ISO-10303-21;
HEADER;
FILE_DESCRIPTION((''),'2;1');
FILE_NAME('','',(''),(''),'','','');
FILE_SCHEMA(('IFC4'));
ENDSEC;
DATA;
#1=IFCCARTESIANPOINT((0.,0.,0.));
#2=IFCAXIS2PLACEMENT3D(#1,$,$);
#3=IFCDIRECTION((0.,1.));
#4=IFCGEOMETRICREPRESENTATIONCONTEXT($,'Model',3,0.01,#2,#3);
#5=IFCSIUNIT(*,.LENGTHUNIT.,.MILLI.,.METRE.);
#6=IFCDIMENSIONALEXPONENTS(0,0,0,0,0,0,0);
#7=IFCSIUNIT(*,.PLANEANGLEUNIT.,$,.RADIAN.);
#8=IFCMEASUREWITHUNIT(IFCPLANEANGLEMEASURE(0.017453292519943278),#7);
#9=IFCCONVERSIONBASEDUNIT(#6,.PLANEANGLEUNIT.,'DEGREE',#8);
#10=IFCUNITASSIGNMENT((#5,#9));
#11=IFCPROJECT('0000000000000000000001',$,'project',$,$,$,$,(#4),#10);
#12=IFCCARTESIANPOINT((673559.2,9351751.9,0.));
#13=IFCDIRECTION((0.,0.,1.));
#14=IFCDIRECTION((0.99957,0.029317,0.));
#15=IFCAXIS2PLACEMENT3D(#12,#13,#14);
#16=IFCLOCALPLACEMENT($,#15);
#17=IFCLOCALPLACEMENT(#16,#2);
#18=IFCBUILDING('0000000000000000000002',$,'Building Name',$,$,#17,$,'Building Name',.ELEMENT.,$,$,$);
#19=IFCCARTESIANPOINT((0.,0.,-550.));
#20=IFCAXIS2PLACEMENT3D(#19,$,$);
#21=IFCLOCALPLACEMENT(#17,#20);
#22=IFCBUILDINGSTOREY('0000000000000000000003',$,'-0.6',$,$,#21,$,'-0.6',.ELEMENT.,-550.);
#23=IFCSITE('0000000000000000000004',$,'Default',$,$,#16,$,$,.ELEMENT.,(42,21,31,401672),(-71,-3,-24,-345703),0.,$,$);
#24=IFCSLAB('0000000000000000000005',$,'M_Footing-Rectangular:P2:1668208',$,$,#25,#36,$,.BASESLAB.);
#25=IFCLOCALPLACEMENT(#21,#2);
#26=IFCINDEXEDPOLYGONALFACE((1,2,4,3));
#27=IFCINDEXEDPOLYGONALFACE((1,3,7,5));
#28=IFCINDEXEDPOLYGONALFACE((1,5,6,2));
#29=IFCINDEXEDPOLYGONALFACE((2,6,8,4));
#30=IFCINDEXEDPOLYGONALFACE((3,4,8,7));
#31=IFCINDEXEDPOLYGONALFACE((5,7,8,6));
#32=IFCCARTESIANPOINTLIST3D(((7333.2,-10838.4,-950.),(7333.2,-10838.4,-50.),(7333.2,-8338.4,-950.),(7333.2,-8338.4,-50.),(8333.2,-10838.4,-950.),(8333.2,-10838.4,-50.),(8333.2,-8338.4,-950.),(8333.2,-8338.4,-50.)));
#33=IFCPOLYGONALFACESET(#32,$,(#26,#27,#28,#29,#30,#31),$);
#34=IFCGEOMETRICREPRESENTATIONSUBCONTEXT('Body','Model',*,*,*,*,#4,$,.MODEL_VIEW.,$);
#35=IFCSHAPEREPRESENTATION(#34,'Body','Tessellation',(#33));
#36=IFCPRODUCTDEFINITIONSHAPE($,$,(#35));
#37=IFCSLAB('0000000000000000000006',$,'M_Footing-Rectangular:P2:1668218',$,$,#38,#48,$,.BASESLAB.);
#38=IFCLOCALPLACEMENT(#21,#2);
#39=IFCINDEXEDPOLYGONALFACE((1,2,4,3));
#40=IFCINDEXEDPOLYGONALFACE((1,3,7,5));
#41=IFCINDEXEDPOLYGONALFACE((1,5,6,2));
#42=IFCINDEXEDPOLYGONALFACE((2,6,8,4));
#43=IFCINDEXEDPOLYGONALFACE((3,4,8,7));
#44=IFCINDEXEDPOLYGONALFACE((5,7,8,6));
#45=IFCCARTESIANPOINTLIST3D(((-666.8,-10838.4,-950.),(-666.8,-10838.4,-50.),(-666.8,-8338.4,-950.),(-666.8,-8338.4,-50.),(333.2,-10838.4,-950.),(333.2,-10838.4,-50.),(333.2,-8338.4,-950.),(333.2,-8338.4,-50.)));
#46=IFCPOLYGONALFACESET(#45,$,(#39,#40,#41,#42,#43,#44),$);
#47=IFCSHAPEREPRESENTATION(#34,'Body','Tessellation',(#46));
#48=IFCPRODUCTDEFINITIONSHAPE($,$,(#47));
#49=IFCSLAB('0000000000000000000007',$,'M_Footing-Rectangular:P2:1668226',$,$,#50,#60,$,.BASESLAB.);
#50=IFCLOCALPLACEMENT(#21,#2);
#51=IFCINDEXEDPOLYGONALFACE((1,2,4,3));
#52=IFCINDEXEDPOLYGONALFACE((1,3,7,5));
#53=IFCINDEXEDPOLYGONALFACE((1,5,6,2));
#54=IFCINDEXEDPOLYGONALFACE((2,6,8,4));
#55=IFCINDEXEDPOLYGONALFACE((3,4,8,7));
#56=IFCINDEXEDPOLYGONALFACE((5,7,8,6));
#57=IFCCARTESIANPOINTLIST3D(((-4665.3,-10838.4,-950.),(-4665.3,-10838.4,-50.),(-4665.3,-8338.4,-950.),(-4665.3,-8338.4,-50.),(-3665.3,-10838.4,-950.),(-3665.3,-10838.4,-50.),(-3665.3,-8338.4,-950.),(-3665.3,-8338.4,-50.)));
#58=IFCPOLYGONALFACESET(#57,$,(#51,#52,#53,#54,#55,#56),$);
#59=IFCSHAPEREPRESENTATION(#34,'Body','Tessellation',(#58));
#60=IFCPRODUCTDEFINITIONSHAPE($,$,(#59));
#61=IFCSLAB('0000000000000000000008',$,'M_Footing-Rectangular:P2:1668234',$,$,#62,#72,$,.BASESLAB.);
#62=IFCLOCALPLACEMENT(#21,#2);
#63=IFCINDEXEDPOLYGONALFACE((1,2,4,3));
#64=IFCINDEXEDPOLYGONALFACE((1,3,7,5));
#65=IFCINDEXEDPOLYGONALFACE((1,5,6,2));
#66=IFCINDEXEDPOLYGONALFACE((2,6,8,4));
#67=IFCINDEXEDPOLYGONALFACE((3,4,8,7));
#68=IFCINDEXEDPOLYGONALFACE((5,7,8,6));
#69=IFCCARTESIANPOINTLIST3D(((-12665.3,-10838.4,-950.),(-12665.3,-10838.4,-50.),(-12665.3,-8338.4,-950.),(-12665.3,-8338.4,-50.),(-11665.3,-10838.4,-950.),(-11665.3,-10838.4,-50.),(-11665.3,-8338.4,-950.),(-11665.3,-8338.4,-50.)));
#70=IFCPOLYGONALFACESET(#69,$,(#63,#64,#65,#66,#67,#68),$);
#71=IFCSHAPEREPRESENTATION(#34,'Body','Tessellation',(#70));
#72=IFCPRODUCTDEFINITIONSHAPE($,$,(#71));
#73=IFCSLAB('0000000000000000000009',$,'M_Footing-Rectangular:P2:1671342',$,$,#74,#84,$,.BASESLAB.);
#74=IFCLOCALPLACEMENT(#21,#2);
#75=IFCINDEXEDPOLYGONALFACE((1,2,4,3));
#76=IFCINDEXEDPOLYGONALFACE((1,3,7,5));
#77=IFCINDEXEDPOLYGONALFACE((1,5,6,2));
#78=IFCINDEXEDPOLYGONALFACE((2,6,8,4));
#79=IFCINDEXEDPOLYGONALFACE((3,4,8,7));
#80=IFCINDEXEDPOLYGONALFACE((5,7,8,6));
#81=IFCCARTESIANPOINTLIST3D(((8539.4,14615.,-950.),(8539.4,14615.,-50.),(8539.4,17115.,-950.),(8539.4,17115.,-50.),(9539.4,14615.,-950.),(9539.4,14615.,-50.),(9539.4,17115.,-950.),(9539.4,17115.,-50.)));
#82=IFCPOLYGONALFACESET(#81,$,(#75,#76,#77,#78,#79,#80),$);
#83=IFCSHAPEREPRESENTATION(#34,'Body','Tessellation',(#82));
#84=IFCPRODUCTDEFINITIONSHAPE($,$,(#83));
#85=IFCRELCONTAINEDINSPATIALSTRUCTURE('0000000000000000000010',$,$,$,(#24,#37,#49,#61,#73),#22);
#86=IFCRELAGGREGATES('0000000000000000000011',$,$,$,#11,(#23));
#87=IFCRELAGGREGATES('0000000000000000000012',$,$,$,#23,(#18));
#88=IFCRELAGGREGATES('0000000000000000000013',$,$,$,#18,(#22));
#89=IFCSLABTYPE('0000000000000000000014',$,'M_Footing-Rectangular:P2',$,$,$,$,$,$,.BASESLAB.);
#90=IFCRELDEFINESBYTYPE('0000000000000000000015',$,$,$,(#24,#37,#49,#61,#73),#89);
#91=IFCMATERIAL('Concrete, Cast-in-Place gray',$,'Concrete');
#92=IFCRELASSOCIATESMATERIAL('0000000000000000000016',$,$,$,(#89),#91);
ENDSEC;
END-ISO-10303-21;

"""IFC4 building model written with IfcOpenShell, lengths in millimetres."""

from ifc_helpers import new_model, entity, si_unit, converted_unit, direction, frame, origin, place, context, subcontext, project, spatial, indexed_curve, outline, extrude, material, type_object, element, save


model = new_model("IFC4")

# Units and contexts
model_context = context("Model", 3, precision=0.01, world=origin(), true_north=direction((0.0, 1.0)))
body_context = subcontext(model_context, "Body", "Model", "MODEL_VIEW")
ifc_project = project(units=[si_unit("LENGTHUNIT", "METRE", prefix="MILLI"), converted_unit("PLANEANGLEUNIT", "DEGREE", entity("IfcPlaneAngleMeasure", 0.017453292519943278), si_unit("PLANEANGLEUNIT", "RADIAN"), dimensions=[0, 0, 0, 0, 0, 0, 0])], contexts=[model_context])

# Site, building, storey
site_placement = place(None, frame((673559.2, 9351751.9, 0.0), z_axis=(0.0, 0.0, 1.0), x_axis=(0.99957, 0.029317, 0.0)))
site = spatial("IfcSite", under=ifc_project, at=site_placement, Name="Default", CompositionType="ELEMENT", RefLatitude=(42, 21, 31, 401672), RefLongitude=(-71, -3, -24, -345703), RefElevation=0.0)
building_placement = place(site_placement, origin())
building = spatial("IfcBuilding", under=site, at=building_placement, Name="Building Name", LongName="Building Name", CompositionType="ELEMENT")
storey_placement = place(building_placement, frame((0.0, 0.0, -550.0)))
storey = spatial("IfcBuildingStorey", under=building, at=storey_placement, Name="-0.6", LongName="-0.6", CompositionType="ELEMENT", Elevation=-550.0)

# Shared definitions
ifc_material = material(Name="Concrete, Cast-in-Place gray", Category="Concrete")

# Slabs
slab_type_1 = type_object("IfcSlabType", Name="M_Footing-Rectangular:P2", PredefinedType="BASESLAB", material=ifc_material)
slab_1_placement = place(storey_placement, origin())
element("IfcSlab", 1, at=slab_1_placement, inside=storey, type_object=slab_type_1, Name="M_Footing-Rectangular:P2:1668208", PredefinedType="BASESLAB", context=body_context, shape_type="SweptSolid", body=[
    extrude(outline(indexed_curve([(-500.0, -1250.0), (500.0, -1250.0), (500.0, 1250.0), (-500.0, 1250.0), (-500.0, -1250.0)], self_intersect=False)), frame((7833.2, -9588.4, -950.0)), (0.0, 0.0, 1.0), 900.0),
])
slab_2_placement = place(storey_placement, origin())
element("IfcSlab", 2, at=slab_2_placement, inside=storey, type_object=slab_type_1, Name="M_Footing-Rectangular:P2:1668218", PredefinedType="BASESLAB", context=body_context, shape_type="SweptSolid", body=[
    extrude(outline(indexed_curve([(-500.0, -1250.0), (500.0, -1250.0), (500.0, 1250.0), (-500.0, 1250.0), (-500.0, -1250.0)], self_intersect=False)), frame((-166.8, -9588.4, -950.0)), (0.0, 0.0, 1.0), 900.0),
])
slab_3_placement = place(storey_placement, origin())
element("IfcSlab", 3, at=slab_3_placement, inside=storey, type_object=slab_type_1, Name="M_Footing-Rectangular:P2:1668226", PredefinedType="BASESLAB", context=body_context, shape_type="SweptSolid", body=[
    extrude(outline(indexed_curve([(-500.0, -1250.0), (500.0, -1250.0), (500.0, 1250.0), (-500.0, 1250.0), (-500.0, -1250.0)], self_intersect=False)), frame((-4165.3, -9588.4, -950.0)), (0.0, 0.0, 1.0), 900.0),
])
slab_4_placement = place(storey_placement, origin())
element("IfcSlab", 4, at=slab_4_placement, inside=storey, type_object=slab_type_1, Name="M_Footing-Rectangular:P2:1668234", PredefinedType="BASESLAB", context=body_context, shape_type="SweptSolid", body=[
    extrude(outline(indexed_curve([(-500.0, -1250.0), (500.0, -1250.0), (500.0, 1250.0), (-500.0, 1250.0), (-500.0, -1250.0)], self_intersect=False)), frame((-12165.3, -9588.4, -950.0)), (0.0, 0.0, 1.0), 900.0),
])
slab_5_placement = place(storey_placement, origin())
element("IfcSlab", 5, at=slab_5_placement, inside=storey, type_object=slab_type_1, Name="M_Footing-Rectangular:P2:1671342", PredefinedType="BASESLAB", context=body_context, shape_type="SweptSolid", body=[
    extrude(outline(indexed_curve([(-500.0, -1250.0), (500.0, -1250.0), (500.0, 1250.0), (-500.0, 1250.0), (-500.0, -1250.0)], self_intersect=False)), frame((9039.4, 15865.0, -950.0), z_axis=(0.0, 0.0, 1.0), x_axis=(-1.0, 0.0, 0.0)), (0.0, 0.0, 1.0), 900.0),
])

save(model, "model.ifc")
